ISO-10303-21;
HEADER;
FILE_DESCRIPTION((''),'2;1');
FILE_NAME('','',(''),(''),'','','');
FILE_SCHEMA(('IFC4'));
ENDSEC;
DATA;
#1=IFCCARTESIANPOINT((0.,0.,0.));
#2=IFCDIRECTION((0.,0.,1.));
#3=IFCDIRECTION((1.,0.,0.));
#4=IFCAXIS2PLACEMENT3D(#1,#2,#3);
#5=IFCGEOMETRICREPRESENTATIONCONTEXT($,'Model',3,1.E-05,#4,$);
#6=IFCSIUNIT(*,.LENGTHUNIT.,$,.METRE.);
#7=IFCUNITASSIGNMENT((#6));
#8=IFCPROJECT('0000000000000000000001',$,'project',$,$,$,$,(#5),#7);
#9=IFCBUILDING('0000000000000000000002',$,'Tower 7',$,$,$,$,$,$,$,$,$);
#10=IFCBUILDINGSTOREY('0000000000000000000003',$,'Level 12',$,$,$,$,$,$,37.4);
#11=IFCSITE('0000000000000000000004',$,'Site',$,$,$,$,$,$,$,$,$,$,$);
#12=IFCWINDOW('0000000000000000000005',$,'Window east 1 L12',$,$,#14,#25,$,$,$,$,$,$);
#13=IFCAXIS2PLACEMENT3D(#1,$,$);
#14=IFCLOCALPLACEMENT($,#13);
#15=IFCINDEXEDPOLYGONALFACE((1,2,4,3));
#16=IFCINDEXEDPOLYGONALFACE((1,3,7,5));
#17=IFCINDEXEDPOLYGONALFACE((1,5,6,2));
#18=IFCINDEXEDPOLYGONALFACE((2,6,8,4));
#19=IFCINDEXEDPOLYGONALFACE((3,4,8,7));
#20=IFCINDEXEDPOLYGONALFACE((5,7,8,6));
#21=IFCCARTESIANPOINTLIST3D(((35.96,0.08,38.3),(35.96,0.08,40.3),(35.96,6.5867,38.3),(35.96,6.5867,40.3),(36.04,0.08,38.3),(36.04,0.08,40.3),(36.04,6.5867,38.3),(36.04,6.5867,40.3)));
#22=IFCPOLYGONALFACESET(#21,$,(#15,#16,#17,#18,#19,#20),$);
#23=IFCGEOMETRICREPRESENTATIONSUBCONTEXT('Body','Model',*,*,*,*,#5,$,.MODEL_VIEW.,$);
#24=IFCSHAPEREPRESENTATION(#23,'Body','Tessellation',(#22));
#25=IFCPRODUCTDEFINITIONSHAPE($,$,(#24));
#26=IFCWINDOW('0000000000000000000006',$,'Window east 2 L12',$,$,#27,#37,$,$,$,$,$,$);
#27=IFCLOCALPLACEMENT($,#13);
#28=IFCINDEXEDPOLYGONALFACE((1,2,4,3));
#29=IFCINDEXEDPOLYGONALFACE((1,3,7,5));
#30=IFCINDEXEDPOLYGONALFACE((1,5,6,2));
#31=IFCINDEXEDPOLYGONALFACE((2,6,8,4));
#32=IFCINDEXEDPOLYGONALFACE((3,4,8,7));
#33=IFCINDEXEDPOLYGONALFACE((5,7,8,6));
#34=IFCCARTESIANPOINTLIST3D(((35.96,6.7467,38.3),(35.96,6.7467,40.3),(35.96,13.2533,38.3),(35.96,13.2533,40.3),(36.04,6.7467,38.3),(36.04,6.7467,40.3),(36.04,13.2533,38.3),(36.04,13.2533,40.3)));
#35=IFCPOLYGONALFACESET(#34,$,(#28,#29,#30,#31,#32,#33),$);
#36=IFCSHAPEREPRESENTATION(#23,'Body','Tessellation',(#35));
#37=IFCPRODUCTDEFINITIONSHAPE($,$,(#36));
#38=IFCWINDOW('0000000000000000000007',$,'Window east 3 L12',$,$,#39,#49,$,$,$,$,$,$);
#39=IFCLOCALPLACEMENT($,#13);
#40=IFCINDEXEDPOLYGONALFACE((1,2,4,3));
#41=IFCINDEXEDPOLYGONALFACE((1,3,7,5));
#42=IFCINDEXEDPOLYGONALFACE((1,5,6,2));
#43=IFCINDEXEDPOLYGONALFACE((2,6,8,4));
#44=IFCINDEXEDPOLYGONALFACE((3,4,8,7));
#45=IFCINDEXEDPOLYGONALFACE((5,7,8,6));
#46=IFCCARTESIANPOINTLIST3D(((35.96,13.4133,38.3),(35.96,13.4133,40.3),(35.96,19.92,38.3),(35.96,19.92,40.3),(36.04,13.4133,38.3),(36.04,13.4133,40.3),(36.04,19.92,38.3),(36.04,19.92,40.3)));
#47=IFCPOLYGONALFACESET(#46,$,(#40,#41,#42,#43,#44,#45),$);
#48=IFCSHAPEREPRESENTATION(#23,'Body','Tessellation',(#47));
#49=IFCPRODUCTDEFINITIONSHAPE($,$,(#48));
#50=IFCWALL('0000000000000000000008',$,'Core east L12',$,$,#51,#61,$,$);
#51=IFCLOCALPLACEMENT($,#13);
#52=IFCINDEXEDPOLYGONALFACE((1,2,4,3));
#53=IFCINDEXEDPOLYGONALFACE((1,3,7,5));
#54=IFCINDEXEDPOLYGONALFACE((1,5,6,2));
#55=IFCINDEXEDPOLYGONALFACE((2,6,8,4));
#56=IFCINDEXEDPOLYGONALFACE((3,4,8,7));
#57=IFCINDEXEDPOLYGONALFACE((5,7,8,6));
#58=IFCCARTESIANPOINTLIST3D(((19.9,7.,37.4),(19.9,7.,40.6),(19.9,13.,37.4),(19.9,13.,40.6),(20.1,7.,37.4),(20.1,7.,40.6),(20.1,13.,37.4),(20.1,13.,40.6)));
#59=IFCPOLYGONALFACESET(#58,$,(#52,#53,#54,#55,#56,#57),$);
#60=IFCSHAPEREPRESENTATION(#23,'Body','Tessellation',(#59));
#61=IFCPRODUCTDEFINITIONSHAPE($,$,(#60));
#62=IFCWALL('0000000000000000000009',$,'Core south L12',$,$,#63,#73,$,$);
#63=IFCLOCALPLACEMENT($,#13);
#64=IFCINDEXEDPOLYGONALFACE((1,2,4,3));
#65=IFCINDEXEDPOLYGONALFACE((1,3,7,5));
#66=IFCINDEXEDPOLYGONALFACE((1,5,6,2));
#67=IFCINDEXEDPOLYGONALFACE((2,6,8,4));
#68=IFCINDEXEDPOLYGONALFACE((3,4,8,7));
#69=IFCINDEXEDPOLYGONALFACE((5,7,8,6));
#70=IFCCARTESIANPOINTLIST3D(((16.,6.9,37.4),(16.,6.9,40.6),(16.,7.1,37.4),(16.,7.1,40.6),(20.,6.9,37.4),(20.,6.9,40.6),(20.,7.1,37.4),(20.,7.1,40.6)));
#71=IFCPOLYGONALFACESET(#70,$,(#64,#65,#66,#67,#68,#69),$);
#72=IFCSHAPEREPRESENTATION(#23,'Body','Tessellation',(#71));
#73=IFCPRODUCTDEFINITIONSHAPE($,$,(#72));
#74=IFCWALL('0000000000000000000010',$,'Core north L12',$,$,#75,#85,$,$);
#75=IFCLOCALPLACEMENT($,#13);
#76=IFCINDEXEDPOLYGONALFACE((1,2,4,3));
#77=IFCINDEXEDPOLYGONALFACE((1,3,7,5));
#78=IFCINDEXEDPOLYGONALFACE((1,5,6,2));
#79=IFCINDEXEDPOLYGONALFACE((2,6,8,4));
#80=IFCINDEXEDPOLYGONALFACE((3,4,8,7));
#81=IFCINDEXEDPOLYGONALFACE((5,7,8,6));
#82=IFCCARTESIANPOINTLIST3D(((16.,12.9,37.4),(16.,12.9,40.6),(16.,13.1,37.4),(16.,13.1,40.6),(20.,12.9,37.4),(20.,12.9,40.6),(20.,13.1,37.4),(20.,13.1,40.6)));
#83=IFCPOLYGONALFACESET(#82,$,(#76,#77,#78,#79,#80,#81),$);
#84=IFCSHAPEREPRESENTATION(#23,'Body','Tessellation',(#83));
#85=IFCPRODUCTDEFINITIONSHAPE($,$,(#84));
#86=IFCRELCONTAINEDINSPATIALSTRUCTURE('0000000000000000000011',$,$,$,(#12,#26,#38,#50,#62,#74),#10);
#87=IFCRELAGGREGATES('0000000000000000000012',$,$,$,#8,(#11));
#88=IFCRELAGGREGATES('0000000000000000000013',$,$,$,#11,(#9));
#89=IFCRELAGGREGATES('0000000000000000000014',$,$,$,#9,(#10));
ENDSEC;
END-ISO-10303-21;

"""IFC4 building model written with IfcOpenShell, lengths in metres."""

from ifc_helpers import new_model, si_unit, frame, origin, origin_with_axes, origin_2d, place, context, subcontext, project, spatial, rectangle, extrude, element, save


model = new_model("IFC4")

# Units and contexts
model_context = context("Model", 3, precision=1e-05, world=origin_with_axes())
body_context = subcontext(model_context, "Body", "Model", "MODEL_VIEW")
ifc_project = project(units=[si_unit("LENGTHUNIT", "METRE")], contexts=[model_context])

# Site, building, storey
site = spatial("IfcSite", under=ifc_project, Name="Site")
building = spatial("IfcBuilding", under=site, Name="Tower 7")
storey = spatial("IfcBuildingStorey", under=building, Name="Level 12", Elevation=37.4)

# Windows
for number, where, z_axis, x_axis, name in (
    (1, (36.0, 3.3333, 38.3), (0.0, 0.0, 1.0), (1.0, 0.0, 0.0), "Window east 1 L12"),
    (2, (36.0, 10.0, 38.3), (0.0, 0.0, 1.0), (1.0, 0.0, 0.0), "Window east 2 L12"),
):
    element("IfcWindow", number, at=place(None, frame(where, z_axis=z_axis, x_axis=x_axis)), inside=storey, Name=name, context=body_context, shape_type="SweptSolid", body=[
        extrude(rectangle(XDim=0.08, YDim=6.5067, at=origin_2d()), origin(), (0.0, 0.0, 1.0), 2.0),
    ])
window_placement = place(None, frame((36.0, 16.6667, 38.3), z_axis=(0.0, 0.0, 1.0), x_axis=(1.0, 0.0, 0.0)))
element("IfcWindow", 3, at=window_placement, inside=storey, Name="Window east 3 L12", context=body_context, shape_type="SweptSolid", body=[
    extrude(rectangle(XDim=0.08, YDim=6.5067, at=origin_2d()), origin(), (0.0, 0.0, 1.0), 2.0),
])

# Walls
wall_1_placement = place(None, frame((20.0, 10.0, 37.4), z_axis=(0.0, 0.0, 1.0), x_axis=(1.0, 0.0, 0.0)))
element("IfcWall", 4, at=wall_1_placement, inside=storey, Name="Core east L12", context=body_context, shape_type="SweptSolid", body=[
    extrude(rectangle(XDim=0.2, YDim=6.0, at=origin_2d()), origin(), (0.0, 0.0, 1.0), 3.2),
])
for number, where, z_axis, x_axis, name in (
    (5, (18.0, 7.0, 37.4), (0.0, 0.0, 1.0), (1.0, 0.0, 0.0), "Core south L12"),
    (6, (18.0, 13.0, 37.4), (0.0, 0.0, 1.0), (1.0, 0.0, 0.0), "Core north L12"),
):
    element("IfcWall", number, at=place(None, frame(where, z_axis=z_axis, x_axis=x_axis)), inside=storey, Name=name, context=body_context, shape_type="SweptSolid", body=[
        extrude(rectangle(XDim=4.0, YDim=0.2, at=origin_2d()), origin(), (0.0, 0.0, 1.0), 3.2),
    ])

save(model, "model.ifc")
